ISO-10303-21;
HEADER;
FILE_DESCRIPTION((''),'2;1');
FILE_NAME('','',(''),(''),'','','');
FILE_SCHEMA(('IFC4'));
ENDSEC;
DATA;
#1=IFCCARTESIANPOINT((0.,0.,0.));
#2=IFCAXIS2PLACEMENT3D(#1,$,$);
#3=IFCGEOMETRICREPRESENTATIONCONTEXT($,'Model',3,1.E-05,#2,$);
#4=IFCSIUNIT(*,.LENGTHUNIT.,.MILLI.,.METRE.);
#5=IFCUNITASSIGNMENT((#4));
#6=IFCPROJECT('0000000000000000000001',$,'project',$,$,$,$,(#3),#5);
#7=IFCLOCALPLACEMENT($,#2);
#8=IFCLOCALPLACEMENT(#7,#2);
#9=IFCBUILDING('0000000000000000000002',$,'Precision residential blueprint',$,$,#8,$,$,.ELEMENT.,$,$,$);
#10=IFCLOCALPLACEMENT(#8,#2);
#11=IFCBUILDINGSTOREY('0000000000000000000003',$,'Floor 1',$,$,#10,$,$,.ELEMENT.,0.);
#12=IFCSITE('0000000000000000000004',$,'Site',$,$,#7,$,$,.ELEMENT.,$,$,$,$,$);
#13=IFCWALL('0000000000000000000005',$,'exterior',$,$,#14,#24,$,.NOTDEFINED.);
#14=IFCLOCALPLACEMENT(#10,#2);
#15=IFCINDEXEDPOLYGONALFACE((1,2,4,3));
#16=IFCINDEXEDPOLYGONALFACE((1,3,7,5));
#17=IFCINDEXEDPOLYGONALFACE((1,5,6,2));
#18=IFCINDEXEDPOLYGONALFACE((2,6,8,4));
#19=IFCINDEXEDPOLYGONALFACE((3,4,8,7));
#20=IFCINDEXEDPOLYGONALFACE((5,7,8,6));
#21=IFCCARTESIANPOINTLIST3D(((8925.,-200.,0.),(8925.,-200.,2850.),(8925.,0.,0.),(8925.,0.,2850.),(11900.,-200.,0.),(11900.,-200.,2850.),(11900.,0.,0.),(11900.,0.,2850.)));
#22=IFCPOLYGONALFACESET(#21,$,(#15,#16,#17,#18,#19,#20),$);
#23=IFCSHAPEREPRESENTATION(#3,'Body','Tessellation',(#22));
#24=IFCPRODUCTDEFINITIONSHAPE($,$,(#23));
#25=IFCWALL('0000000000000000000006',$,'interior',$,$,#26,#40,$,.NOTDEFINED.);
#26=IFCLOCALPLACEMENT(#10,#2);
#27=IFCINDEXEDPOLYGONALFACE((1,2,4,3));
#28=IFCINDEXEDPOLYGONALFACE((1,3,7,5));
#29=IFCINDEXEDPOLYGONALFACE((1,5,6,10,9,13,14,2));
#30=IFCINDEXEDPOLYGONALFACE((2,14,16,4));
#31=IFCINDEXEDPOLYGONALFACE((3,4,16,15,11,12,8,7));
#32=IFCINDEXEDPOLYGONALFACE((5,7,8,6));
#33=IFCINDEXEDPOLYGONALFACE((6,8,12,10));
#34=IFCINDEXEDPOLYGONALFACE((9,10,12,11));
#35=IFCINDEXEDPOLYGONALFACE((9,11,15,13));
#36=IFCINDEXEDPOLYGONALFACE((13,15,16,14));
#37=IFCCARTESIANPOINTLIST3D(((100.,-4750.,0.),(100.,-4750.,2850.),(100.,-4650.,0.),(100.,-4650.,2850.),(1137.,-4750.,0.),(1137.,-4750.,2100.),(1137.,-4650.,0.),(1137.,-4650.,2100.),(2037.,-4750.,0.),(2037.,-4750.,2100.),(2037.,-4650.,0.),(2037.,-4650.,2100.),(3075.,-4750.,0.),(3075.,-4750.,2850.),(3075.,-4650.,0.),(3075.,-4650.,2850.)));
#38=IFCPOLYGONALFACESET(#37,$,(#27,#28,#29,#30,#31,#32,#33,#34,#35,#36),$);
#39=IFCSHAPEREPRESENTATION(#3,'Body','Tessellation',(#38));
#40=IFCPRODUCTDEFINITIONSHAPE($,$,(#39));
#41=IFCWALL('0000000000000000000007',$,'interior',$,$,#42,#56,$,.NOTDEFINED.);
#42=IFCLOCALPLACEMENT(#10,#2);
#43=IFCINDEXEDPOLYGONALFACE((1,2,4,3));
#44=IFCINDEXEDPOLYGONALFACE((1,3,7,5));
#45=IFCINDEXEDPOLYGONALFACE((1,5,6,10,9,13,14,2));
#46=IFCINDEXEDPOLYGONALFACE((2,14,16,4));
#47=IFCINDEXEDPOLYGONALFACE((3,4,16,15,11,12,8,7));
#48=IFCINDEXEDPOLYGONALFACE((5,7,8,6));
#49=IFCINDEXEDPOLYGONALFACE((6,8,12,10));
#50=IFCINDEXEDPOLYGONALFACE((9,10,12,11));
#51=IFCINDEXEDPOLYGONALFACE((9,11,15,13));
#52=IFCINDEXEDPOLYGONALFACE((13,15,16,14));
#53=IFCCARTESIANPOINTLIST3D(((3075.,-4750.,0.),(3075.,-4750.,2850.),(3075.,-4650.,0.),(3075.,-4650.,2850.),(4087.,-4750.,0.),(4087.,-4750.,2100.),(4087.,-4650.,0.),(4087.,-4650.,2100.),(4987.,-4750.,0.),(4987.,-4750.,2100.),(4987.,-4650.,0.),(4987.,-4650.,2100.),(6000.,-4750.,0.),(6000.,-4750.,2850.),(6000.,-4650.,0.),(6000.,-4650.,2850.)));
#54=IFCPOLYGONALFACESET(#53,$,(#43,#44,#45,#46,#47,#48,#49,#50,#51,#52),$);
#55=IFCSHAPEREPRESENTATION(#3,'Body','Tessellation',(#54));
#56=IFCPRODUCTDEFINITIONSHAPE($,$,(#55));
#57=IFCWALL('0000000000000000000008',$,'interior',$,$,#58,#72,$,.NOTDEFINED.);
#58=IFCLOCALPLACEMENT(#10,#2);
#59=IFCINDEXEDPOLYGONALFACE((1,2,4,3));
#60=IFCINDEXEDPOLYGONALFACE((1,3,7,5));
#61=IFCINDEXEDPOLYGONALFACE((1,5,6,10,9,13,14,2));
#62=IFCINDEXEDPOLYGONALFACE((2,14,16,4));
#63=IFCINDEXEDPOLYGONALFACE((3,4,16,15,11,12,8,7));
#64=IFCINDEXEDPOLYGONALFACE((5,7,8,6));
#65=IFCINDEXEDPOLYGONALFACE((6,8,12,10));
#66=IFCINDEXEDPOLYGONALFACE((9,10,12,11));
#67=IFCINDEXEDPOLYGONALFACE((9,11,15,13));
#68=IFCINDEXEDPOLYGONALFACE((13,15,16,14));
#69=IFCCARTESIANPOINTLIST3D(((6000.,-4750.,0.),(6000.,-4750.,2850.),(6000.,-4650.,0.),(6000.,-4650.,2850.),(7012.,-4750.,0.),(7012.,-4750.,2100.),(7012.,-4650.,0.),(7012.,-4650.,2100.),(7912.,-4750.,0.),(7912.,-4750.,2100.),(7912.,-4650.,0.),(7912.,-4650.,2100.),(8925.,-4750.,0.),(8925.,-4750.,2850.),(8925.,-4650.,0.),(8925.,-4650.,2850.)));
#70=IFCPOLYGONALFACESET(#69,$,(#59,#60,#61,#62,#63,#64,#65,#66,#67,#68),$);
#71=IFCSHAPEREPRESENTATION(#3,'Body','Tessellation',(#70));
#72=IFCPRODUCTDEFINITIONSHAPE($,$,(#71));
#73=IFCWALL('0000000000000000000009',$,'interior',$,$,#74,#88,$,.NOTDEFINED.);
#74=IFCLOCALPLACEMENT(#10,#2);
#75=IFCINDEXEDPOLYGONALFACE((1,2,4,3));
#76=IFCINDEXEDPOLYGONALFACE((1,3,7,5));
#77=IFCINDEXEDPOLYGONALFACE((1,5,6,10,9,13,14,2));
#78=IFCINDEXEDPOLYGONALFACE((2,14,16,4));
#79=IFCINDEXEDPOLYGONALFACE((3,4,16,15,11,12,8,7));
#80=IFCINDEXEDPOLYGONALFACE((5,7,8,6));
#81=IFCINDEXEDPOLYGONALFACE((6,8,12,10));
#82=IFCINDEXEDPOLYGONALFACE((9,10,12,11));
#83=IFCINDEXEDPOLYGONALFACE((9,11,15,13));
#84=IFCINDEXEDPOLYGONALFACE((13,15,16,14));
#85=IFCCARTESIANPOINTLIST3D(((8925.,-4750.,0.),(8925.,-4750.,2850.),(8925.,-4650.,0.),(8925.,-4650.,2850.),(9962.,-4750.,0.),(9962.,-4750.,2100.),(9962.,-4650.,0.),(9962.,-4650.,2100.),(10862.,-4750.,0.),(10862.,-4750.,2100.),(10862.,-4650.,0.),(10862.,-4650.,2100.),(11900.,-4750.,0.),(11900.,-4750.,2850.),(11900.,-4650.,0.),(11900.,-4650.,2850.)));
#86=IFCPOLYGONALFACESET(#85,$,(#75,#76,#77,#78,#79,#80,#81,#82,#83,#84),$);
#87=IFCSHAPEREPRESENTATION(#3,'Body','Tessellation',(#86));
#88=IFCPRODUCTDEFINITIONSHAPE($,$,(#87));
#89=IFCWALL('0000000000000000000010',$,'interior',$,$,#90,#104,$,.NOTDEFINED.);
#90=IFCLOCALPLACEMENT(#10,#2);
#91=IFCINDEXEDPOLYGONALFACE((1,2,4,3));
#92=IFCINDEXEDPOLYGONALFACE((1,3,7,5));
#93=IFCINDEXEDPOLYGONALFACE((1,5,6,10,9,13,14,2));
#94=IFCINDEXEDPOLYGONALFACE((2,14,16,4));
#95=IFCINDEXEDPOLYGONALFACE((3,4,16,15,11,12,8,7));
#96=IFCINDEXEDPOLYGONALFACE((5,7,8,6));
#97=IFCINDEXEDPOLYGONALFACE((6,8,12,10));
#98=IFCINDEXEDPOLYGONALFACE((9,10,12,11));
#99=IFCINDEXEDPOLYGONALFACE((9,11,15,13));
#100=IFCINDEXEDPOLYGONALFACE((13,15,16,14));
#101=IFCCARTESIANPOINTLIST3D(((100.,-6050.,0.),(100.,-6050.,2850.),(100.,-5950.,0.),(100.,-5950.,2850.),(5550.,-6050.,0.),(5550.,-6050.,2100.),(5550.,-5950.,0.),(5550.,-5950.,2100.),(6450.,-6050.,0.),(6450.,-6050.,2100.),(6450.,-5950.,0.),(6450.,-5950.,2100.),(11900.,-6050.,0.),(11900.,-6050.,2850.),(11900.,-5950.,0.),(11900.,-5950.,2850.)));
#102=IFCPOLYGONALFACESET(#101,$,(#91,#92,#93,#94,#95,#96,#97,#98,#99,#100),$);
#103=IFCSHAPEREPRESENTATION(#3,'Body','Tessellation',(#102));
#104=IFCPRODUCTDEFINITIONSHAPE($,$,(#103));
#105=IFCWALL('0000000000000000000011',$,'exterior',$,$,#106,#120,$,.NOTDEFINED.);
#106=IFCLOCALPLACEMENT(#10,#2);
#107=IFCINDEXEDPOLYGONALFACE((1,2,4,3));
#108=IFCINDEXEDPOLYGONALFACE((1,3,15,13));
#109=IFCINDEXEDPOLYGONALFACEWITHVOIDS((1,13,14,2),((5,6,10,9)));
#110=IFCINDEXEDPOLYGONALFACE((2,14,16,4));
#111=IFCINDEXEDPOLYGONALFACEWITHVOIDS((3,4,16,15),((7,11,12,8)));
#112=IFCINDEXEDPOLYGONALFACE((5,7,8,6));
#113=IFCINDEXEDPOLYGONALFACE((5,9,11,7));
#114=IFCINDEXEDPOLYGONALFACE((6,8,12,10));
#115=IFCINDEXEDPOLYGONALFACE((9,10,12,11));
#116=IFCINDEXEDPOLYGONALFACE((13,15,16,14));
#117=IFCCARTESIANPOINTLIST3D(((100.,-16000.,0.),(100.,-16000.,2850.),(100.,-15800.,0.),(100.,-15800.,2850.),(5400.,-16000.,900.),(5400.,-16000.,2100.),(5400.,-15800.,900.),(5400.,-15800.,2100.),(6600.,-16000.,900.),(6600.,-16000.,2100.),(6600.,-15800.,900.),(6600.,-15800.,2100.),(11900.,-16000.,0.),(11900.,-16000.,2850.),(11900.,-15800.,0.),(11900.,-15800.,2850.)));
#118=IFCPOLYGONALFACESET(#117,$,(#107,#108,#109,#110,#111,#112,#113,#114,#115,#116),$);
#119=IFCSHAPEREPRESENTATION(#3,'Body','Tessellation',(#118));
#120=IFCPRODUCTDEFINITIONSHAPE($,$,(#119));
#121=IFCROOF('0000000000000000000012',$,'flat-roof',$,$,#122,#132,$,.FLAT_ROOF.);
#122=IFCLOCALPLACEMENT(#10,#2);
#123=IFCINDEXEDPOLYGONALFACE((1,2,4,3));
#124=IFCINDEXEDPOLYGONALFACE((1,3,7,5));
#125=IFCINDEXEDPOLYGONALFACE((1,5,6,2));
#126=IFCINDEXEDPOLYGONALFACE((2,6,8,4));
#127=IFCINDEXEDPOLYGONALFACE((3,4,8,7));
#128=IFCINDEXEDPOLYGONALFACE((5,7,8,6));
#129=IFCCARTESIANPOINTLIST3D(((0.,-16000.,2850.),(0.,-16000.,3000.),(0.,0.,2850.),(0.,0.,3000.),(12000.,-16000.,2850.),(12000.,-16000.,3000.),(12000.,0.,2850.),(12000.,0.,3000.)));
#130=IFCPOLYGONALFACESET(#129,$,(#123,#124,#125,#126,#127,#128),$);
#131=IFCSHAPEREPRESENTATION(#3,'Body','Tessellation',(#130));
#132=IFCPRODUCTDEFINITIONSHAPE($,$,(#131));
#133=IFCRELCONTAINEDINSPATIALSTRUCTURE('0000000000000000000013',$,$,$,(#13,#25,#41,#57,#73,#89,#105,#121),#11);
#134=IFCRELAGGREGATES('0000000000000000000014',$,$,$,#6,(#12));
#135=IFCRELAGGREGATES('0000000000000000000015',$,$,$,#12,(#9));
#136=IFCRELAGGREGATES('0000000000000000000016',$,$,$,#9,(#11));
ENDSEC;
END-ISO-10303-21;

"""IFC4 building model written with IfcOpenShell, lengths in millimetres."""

from ifc_helpers import new_model, si_unit, frame, origin, place, context, project, spatial, polyline, outline, extrude, element, save


model = new_model("IFC4")

# Units and contexts
model_context = context("Model", 3, precision=1e-05, world=origin())
ifc_project = project(units=[si_unit("LENGTHUNIT", "METRE", prefix="MILLI")], contexts=[model_context])

# Site, building, storey
site_placement = place(None, origin())
site = spatial("IfcSite", under=ifc_project, at=site_placement, Name="Site", CompositionType="ELEMENT")
building_placement = place(site_placement, origin())
building = spatial("IfcBuilding", under=site, at=building_placement, Name="Precision residential blueprint", CompositionType="ELEMENT")
storey_placement = place(building_placement, origin())
storey = spatial("IfcBuildingStorey", under=building, at=storey_placement, Name="Floor 1", CompositionType="ELEMENT", Elevation=0.0)

# Wall
wall_1_placement = place(storey_placement, origin())
element("IfcWall", 1, at=wall_1_placement, inside=storey, Name="exterior", PredefinedType="NOTDEFINED", context=model_context, shape_type="SweptSolid", body=[
    extrude(outline(polyline([(8925.0, 0.0), (11900.0, 0.0), (11900.0, -200.0), (8925.0, -200.0), (8925.0, 0.0)])), origin(), (0.0, 0.0, 1.0), 2850.0),
])

# Walls, openings
wall_2_placement = place(storey_placement, origin())
wall_2 = element("IfcWall", 2, at=wall_2_placement, inside=storey, Name="interior", PredefinedType="NOTDEFINED", context=model_context, shape_type="SweptSolid", body=[
    extrude(outline(polyline([(100.0, -4650.0), (3075.0, -4650.0), (3075.0, -4750.0), (100.0, -4750.0), (100.0, -4650.0)])), origin(), (0.0, 0.0, 1.0), 2850.0),
])
opening_1_placement = place(storey_placement, origin())
element("IfcOpeningElement", 3, at=opening_1_placement, cuts=wall_2, PredefinedType="OPENING", context=model_context, shape_type="SweptSolid", body=[
    extrude(outline(polyline([(1137.0, -4650.0), (2037.0, -4650.0), (2037.0, -4750.0), (1137.0, -4750.0), (1137.0, -4650.0)])), origin(), (0.0, 0.0, 1.0), 2100.0),
])
wall_3_placement = place(storey_placement, origin())
wall_3 = element("IfcWall", 4, at=wall_3_placement, inside=storey, Name="interior", PredefinedType="NOTDEFINED", context=model_context, shape_type="SweptSolid", body=[
    extrude(outline(polyline([(3075.0, -4650.0), (6000.0, -4650.0), (6000.0, -4750.0), (3075.0, -4750.0), (3075.0, -4650.0)])), origin(), (0.0, 0.0, 1.0), 2850.0),
])
opening_2_placement = place(storey_placement, origin())
element("IfcOpeningElement", 5, at=opening_2_placement, cuts=wall_3, PredefinedType="OPENING", context=model_context, shape_type="SweptSolid", body=[
    extrude(outline(polyline([(4087.0, -4650.0), (4987.0, -4650.0), (4987.0, -4750.0), (4087.0, -4750.0), (4087.0, -4650.0)])), origin(), (0.0, 0.0, 1.0), 2100.0),
])
wall_4_placement = place(storey_placement, origin())
wall_4 = element("IfcWall", 6, at=wall_4_placement, inside=storey, Name="interior", PredefinedType="NOTDEFINED", context=model_context, shape_type="SweptSolid", body=[
    extrude(outline(polyline([(6000.0, -4650.0), (8925.0, -4650.0), (8925.0, -4750.0), (6000.0, -4750.0), (6000.0, -4650.0)])), origin(), (0.0, 0.0, 1.0), 2850.0),
])
opening_3_placement = place(storey_placement, origin())
element("IfcOpeningElement", 7, at=opening_3_placement, cuts=wall_4, PredefinedType="OPENING", context=model_context, shape_type="SweptSolid", body=[
    extrude(outline(polyline([(7012.0, -4650.0), (7912.0, -4650.0), (7912.0, -4750.0), (7012.0, -4750.0), (7012.0, -4650.0)])), origin(), (0.0, 0.0, 1.0), 2100.0),
])
wall_5_placement = place(storey_placement, origin())
wall_5 = element("IfcWall", 8, at=wall_5_placement, inside=storey, Name="interior", PredefinedType="NOTDEFINED", context=model_context, shape_type="SweptSolid", body=[
    extrude(outline(polyline([(8925.0, -4650.0), (11900.0, -4650.0), (11900.0, -4750.0), (8925.0, -4750.0), (8925.0, -4650.0)])), origin(), (0.0, 0.0, 1.0), 2850.0),
])
opening_4_placement = place(storey_placement, origin())
element("IfcOpeningElement", 9, at=opening_4_placement, cuts=wall_5, PredefinedType="OPENING", context=model_context, shape_type="SweptSolid", body=[
    extrude(outline(polyline([(9962.0, -4650.0), (10862.0, -4650.0), (10862.0, -4750.0), (9962.0, -4750.0), (9962.0, -4650.0)])), origin(), (0.0, 0.0, 1.0), 2100.0),
])
wall_6_placement = place(storey_placement, origin())
wall_6 = element("IfcWall", 10, at=wall_6_placement, inside=storey, Name="interior", PredefinedType="NOTDEFINED", context=model_context, shape_type="SweptSolid", body=[
    extrude(outline(polyline([(100.0, -5950.0), (11900.0, -5950.0), (11900.0, -6050.0), (100.0, -6050.0), (100.0, -5950.0)])), origin(), (0.0, 0.0, 1.0), 2850.0),
])
opening_5_placement = place(storey_placement, origin())
element("IfcOpeningElement", 11, at=opening_5_placement, cuts=wall_6, PredefinedType="OPENING", context=model_context, shape_type="SweptSolid", body=[
    extrude(outline(polyline([(5550.0, -5950.0), (6450.0, -5950.0), (6450.0, -6050.0), (5550.0, -6050.0), (5550.0, -5950.0)])), origin(), (0.0, 0.0, 1.0), 2100.0),
])
wall_7_placement = place(storey_placement, origin())
wall_7 = element("IfcWall", 12, at=wall_7_placement, inside=storey, Name="exterior", PredefinedType="NOTDEFINED", context=model_context, shape_type="SweptSolid", body=[
    extrude(outline(polyline([(100.0, -15800.0), (11900.0, -15800.0), (11900.0, -16000.0), (100.0, -16000.0), (100.0, -15800.0)])), origin(), (0.0, 0.0, 1.0), 2850.0),
])
opening_6_placement = place(storey_placement, origin())
element("IfcOpeningElement", 13, at=opening_6_placement, cuts=wall_7, PredefinedType="OPENING", context=model_context, shape_type="SweptSolid", body=[
    extrude(outline(polyline([(5400.0, -15800.0), (6600.0, -15800.0), (6600.0, -16000.0), (5400.0, -16000.0), (5400.0, -15800.0)])), frame((0.0, 0.0, 900.0)), (0.0, 0.0, 1.0), 1200.0),
])

# Roof
roof_placement = place(storey_placement, origin())
element("IfcRoof", 14, at=roof_placement, inside=storey, Name="flat-roof", PredefinedType="FLAT_ROOF", context=model_context, shape_type="SweptSolid", body=[
    extrude(outline(polyline([(0.0, -16000.0), (12000.0, -16000.0), (12000.0, 0.0), (0.0, 0.0), (0.0, -16000.0)])), frame((0.0, 0.0, 2850.0)), (0.0, 0.0, 1.0), 150.0),
])

save(model, "model.ifc")
